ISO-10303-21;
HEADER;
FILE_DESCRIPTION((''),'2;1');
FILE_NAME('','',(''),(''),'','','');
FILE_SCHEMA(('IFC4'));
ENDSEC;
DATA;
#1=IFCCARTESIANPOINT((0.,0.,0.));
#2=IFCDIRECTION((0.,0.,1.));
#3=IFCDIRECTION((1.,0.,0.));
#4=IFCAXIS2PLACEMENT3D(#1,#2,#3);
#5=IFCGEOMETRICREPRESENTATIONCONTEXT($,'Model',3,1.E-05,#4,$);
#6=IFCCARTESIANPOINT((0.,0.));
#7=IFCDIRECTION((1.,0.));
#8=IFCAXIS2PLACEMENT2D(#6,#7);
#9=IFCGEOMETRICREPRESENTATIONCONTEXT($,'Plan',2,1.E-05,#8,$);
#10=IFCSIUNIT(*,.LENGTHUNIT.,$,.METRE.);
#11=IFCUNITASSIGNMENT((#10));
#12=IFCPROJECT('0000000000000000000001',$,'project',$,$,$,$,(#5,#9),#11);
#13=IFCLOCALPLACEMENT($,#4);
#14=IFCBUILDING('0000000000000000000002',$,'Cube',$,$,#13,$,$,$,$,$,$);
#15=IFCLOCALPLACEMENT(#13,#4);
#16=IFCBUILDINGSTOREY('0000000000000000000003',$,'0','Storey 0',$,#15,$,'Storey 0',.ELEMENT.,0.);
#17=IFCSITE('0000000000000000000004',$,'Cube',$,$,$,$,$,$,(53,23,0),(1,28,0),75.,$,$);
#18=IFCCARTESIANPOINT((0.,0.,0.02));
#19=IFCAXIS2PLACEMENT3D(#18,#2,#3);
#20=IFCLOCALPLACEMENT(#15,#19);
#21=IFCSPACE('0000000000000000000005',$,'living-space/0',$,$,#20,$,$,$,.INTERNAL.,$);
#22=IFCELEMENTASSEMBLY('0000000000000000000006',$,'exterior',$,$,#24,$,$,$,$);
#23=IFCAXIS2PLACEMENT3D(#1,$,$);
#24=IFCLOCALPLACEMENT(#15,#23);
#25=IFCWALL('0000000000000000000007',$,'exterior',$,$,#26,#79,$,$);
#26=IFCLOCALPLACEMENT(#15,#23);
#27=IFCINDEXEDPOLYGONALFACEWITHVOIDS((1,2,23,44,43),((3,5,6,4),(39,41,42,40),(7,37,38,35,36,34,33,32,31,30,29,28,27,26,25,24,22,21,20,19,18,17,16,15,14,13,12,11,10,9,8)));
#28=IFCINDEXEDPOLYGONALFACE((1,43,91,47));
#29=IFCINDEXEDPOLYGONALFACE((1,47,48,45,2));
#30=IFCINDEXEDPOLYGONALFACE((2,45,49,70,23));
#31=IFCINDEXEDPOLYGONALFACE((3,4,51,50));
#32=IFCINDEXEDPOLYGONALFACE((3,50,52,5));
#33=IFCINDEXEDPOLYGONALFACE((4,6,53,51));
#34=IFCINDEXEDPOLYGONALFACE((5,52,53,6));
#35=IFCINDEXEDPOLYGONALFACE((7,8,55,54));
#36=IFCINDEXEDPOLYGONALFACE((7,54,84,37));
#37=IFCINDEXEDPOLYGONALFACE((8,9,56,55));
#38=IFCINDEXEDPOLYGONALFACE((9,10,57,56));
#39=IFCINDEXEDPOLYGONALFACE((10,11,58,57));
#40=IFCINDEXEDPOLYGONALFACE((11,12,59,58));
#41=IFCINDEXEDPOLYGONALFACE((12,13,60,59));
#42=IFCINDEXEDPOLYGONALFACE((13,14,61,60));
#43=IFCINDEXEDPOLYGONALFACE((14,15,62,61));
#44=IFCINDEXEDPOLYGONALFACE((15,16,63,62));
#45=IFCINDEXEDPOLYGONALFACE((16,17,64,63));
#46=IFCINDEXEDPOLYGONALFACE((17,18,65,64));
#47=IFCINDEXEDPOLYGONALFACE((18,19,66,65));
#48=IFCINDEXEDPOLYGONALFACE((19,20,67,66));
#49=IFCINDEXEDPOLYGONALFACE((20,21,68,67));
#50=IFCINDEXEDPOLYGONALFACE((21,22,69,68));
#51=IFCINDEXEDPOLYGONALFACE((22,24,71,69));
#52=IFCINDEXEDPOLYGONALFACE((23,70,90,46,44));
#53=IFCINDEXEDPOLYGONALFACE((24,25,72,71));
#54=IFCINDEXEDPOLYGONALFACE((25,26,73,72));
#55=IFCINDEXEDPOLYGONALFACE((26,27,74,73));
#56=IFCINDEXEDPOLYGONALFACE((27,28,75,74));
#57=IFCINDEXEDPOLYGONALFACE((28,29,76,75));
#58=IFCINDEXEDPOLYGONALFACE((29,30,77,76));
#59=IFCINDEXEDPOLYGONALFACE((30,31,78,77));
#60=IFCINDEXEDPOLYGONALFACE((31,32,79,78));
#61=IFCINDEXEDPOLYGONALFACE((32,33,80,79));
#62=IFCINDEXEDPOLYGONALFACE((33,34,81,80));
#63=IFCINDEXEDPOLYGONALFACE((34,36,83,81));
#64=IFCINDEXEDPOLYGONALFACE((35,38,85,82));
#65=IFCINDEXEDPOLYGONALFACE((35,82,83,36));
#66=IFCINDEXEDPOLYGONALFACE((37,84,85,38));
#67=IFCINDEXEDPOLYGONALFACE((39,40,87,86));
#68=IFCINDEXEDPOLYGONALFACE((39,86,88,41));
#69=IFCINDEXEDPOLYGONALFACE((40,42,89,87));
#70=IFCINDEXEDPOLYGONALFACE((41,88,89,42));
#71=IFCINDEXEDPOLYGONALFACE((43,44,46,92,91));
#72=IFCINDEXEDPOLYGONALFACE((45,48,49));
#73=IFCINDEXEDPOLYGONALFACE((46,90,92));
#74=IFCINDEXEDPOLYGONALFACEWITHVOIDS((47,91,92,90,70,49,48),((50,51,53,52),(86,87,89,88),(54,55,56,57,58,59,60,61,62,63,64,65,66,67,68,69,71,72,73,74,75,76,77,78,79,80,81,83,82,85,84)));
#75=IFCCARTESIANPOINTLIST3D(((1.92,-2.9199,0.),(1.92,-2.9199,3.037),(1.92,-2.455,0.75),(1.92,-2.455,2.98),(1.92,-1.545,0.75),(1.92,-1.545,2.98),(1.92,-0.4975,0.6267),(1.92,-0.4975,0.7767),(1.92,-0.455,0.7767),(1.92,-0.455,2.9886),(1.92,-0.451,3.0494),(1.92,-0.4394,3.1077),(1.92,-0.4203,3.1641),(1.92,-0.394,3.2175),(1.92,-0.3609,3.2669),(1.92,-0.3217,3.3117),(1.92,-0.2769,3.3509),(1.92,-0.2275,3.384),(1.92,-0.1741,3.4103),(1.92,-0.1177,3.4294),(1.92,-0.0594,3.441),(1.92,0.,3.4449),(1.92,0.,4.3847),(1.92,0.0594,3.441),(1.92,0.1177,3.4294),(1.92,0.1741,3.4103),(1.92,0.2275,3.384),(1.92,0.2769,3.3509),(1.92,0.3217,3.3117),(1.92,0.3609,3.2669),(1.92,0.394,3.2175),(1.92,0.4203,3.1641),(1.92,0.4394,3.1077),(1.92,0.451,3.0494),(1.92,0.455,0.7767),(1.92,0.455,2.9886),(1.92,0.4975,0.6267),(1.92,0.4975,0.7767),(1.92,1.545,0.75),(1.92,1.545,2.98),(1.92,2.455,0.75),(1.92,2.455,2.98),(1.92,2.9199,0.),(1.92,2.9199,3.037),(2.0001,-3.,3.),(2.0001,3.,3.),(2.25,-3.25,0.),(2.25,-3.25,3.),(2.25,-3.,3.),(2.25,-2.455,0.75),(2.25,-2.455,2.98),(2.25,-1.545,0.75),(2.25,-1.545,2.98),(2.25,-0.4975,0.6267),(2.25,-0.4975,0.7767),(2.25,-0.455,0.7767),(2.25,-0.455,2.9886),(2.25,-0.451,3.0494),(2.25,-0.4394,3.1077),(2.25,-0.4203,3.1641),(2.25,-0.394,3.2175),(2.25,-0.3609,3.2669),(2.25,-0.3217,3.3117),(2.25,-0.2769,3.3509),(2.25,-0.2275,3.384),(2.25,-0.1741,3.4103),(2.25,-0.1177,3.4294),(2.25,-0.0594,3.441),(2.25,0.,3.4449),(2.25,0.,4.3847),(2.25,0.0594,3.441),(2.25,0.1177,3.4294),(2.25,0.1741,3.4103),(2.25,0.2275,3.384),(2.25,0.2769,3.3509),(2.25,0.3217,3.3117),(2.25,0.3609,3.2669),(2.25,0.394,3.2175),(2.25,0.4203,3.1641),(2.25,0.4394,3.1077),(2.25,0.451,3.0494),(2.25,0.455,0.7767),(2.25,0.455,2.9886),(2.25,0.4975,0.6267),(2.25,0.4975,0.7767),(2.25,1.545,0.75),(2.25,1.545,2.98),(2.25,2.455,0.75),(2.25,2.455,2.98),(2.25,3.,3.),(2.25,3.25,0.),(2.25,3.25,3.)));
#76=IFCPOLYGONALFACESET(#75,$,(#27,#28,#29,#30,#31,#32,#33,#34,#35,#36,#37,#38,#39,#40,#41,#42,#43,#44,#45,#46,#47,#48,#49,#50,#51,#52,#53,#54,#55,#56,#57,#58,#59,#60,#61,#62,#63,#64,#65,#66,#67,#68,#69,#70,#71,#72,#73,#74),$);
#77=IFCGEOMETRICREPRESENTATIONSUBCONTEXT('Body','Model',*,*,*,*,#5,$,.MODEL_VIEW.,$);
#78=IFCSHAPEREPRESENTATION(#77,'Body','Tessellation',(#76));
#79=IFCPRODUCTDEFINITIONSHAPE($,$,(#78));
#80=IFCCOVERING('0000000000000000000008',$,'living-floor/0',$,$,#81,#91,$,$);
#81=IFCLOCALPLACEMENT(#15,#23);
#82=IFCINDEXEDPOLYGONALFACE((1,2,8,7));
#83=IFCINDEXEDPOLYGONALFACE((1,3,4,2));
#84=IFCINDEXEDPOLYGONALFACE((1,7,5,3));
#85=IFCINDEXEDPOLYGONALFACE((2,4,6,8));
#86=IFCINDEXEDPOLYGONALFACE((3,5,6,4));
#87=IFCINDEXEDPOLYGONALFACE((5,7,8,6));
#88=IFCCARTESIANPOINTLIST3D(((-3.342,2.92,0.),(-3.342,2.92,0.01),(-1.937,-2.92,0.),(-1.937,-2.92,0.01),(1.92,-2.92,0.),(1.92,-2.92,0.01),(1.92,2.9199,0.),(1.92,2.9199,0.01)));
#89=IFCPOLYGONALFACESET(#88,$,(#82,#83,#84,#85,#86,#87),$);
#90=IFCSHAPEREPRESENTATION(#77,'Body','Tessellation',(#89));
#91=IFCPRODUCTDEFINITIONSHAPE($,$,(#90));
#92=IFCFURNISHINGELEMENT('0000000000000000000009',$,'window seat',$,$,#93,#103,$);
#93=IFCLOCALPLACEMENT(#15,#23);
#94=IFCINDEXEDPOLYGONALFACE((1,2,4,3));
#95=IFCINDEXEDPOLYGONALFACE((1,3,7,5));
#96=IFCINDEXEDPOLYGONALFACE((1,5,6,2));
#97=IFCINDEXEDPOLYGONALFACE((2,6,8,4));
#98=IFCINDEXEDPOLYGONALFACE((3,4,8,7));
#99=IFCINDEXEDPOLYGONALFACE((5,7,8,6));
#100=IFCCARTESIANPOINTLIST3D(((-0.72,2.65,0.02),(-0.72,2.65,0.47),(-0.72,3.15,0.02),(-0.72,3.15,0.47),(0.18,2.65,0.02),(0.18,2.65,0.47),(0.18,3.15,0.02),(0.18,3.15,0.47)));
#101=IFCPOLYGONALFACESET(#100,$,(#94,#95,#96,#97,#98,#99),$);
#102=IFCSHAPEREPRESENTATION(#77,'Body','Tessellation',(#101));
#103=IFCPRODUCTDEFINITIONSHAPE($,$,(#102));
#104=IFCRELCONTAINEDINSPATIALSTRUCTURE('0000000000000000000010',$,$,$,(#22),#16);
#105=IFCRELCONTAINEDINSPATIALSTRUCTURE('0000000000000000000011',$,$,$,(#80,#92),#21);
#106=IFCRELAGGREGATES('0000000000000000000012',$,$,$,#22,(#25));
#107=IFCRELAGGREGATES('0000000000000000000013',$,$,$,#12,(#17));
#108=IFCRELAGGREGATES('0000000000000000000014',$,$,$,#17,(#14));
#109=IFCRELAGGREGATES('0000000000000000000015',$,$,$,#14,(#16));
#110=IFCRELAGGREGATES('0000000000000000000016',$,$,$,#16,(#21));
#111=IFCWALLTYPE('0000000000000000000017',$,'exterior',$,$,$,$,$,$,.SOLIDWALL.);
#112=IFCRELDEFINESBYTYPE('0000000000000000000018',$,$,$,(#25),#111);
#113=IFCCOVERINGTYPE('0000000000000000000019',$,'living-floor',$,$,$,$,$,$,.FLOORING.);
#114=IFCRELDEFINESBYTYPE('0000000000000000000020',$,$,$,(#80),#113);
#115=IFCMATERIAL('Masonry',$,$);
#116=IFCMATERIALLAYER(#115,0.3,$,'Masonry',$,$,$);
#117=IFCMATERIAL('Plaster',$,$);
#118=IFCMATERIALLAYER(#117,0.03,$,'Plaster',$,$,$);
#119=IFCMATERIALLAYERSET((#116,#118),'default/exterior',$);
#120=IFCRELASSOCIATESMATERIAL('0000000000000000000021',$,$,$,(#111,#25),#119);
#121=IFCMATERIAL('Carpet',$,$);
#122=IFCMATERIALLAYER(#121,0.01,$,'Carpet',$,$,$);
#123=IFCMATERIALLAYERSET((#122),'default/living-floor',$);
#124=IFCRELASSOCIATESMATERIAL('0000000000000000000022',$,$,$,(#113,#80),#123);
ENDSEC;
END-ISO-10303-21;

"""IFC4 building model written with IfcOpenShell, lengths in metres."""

from ifc_helpers import new_model, si_unit, frame, origin, origin_with_axes, origin_2d_with_axis, place, context, subcontext, project, spatial, polyline, indexed_curve, outline, extrude, clip, bounded_halfspace, material, layer, layer_set, layer_usage, type_object, element, aggregate, save


model = new_model("IFC4")

# Units and contexts
model_context = context("Model", 3, precision=1e-05, world=origin_with_axes())
plan_context = context("Plan", 2, precision=1e-05, world=origin_2d_with_axis())
body_context = subcontext(model_context, "Body", "Model", "MODEL_VIEW")
ifc_project = project(units=[si_unit("LENGTHUNIT", "METRE")], contexts=[model_context, plan_context])

# Site, building, storey
site = spatial("IfcSite", under=ifc_project, Name="Cube", RefLatitude=(53, 23, 0), RefLongitude=(1, 28, 0), RefElevation=75.0)
building_placement = place(None, origin_with_axes())
building = spatial("IfcBuilding", under=site, at=building_placement, Name="Cube")
storey_placement = place(building_placement, origin_with_axes())
storey = spatial("IfcBuildingStorey", under=building, at=storey_placement, Name="0", Description="Storey 0", LongName="Storey 0", CompositionType="ELEMENT", Elevation=0.0)

# Element assembly, wall, openings
ifc_material_1 = material(Name="Masonry")
ifc_layer_1 = layer(ifc_material_1, 0.3, Name="Masonry")
ifc_material_2 = material(Name="Plaster")
ifc_layer_2 = layer(ifc_material_2, 0.03, Name="Plaster")
ifc_layer_set_1 = layer_set([ifc_layer_1, ifc_layer_2], Name="default/exterior")
wall_type = type_object("IfcWallType", Name="exterior", PredefinedType="SOLIDWALL", material=ifc_layer_set_1)
assembly_1_placement = place(storey_placement, frame((2.0, -3.0, 0.0), z_axis=(0.0, 0.0, 1.0), x_axis=(0.0, 1.0, 0.0)))
assembly_1 = element("IfcElementAssembly", 1, at=assembly_1_placement, inside=storey, Name="exterior")
ifc_layer_usage_1 = layer_usage(ifc_layer_set_1, "AXIS2", "POSITIVE", -0.25)
wall_1_placement = place(assembly_1_placement, origin_with_axes())
wall_1 = element("IfcWall", 2, at=wall_1_placement, type_object=wall_type, material=ifc_layer_usage_1, Name="exterior", context=body_context, shape_type="Clipping", body=[
    clip(clip(clip(clip(extrude(outline(polyline([(0.0801, 0.08), (-0.25, -0.25), (6.25, -0.25), (5.9199, 0.08), (0.0801, 0.08)])), origin(), (0.0, 0.0, 1.0), 4.385), bounded_halfspace(frame((6.0, 0.0, 3.0), z_axis=(0.419069, 0.0, 0.907954), x_axis=(0.0, -1.0, 0.0)), False, origin(), polyline([(6.0, -1.0), (3.0, -1.0), (3.0, 1.0), (6.0, 1.0), (6.0, -1.0)]))), bounded_halfspace(frame((6.0, 0.0, 3.0), z_axis=(0.0, 0.0, 1.0), x_axis=(0.0, 1.0, 0.0)), False, origin(), polyline([(6.0, 1.0), (7.0, 1.0), (7.0, -1.0), (6.0, -1.0), (6.0, 1.0)]))), bounded_halfspace(frame((3.0, 0.0, 4.3847), z_axis=(-0.419069, 0.0, 0.907954), x_axis=(0.0, -1.0, 0.0)), False, origin(), polyline([(3.0, -1.0), (0.0, -1.0), (0.0, 1.0), (3.0, 1.0), (3.0, -1.0)]))), bounded_halfspace(frame((0.0, 0.0, 3.0), z_axis=(0.0, 0.0, 1.0), x_axis=(0.0, -1.0, 0.0)), False, origin(), polyline([(0.0, -1.0), (-1.0, -1.0), (-1.0, 1.0), (0.0, 1.0), (0.0, -1.0)]))),
])
opening_1_placement = place(wall_1_placement, frame((0.545, -0.25, 0.75), z_axis=(0.0, 0.0, 1.0), x_axis=(1.0, 0.0, 0.0)))
element("IfcOpeningElement", 3, at=opening_1_placement, cuts=wall_1, PredefinedType="OPENING", context=body_context, shape_type="SweptSolid", body=[
    extrude(outline(polyline([(0.0, -0.02), (0.91, -0.02), (0.91, 0.35), (0.0, 0.35), (0.0, -0.02)])), origin(), (0.0, 0.0, 1.0), 2.23),
])
opening_2_placement = place(wall_1_placement, frame((2.545, -0.25, 0.75), z_axis=(0.0, 0.0, 1.0), x_axis=(1.0, 0.0, 0.0)))
element("IfcOpeningElement", 4, at=opening_2_placement, cuts=wall_1, PredefinedType="OPENING", context=body_context, shape_type="SweptSolid", body=[
    extrude(outline(polyline([(0.1333, 2.5617), (0.1781, 2.6009), (0.2275, 2.634), (0.2809, 2.6603), (0.3373, 2.6794), (0.3956, 2.691), (0.455, 2.6949), (0.5144, 2.691), (0.5727, 2.6794), (0.6291, 2.6603), (0.6825, 2.634), (0.7319, 2.6009), (0.7767, 2.5617), (0.8159, 2.5169), (0.849, 2.4675), (0.8753, 2.4141), (0.8944, 2.3577), (0.906, 2.2994), (0.91, 2.2386), (0.91, 2.2069), (0.91, 0.0267), (0.9525, 0.0267), (0.9525, -0.1233), (-0.0425, -0.1233), (-0.0425, 0.0267), (0.0, 0.0267), (0.0, 2.2069), (0.0, 2.2386), (0.004, 2.2994), (0.0156, 2.3577), (0.0347, 2.4141), (0.061, 2.4675), (0.0941, 2.5169), (0.1333, 2.5617)])), frame((0.0, -0.02, 0.0), z_axis=(0.0, -1.0, 0.0), x_axis=(1.0, 0.0, 0.0)), (0.0, 0.0, -1.0), 0.37),
])
opening_3_placement = place(wall_1_placement, frame((4.545, -0.25, 0.75), z_axis=(0.0, 0.0, 1.0), x_axis=(1.0, 0.0, 0.0)))
element("IfcOpeningElement", 5, at=opening_3_placement, cuts=wall_1, PredefinedType="OPENING", context=body_context, shape_type="SweptSolid", body=[
    extrude(outline(polyline([(0.0, -0.02), (0.91, -0.02), (0.91, 0.35), (0.0, 0.35), (0.0, -0.02)])), origin(), (0.0, 0.0, 1.0), 2.23),
])
aggregate(assembly_1, [wall_1])

# Shared definitions
space_placement = place(storey_placement, frame((0.0, 0.0, 0.02), z_axis=(0.0, 0.0, 1.0), x_axis=(1.0, 0.0, 0.0)))
space = spatial("IfcSpace", under=storey, at=space_placement, Name="living-space/0", PredefinedType="INTERNAL")

# Covering
ifc_material_3 = material(Name="Carpet")
ifc_layer_3 = layer(ifc_material_3, 0.01, Name="Carpet")
ifc_layer_set_2 = layer_set([ifc_layer_3], Name="default/living-floor")
ifc_layer_usage_2 = layer_usage(ifc_layer_set_2, "AXIS3", "POSITIVE", 0.0)
covering_type = type_object("IfcCoveringType", Name="living-floor", PredefinedType="FLOORING", material=ifc_layer_set_2)
covering_placement = place(space_placement, frame((0.0, 0.0, -0.02), z_axis=(0.0, 0.0, 1.0), x_axis=(1.0, 0.0, 0.0)))
element("IfcCovering", 6, at=covering_placement, inside=space, type_object=covering_type, material=ifc_layer_usage_2, Name="living-floor/0", context=body_context, shape_type="SweptSolid", body=[
    extrude(outline(polyline([(1.92, 2.9199), (-3.342, 2.92), (-1.937, -2.92), (1.92, -2.92), (1.92, 2.9199)])), origin_with_axes(), (0.0, 0.0, 1.0), 0.01),
])

# Furnishing element
furnishing_placement = place(space_placement, frame((-0.72, 2.65, 0.0), z_axis=(0.0, 0.0, 1.0), x_axis=(1.0, 0.0, 0.0)))
element("IfcFurnishingElement", 7, at=furnishing_placement, inside=space, Name="window seat", context=body_context, shape_type="SweptSolid", body=[
    extrude(outline(indexed_curve([(0.0, 0.0), (0.9, 0.0), (0.9, 0.5), (0.0, 0.5)])), None, (0.0, 0.0, 1.0), 0.45),
])

save(model, "model.ifc")
